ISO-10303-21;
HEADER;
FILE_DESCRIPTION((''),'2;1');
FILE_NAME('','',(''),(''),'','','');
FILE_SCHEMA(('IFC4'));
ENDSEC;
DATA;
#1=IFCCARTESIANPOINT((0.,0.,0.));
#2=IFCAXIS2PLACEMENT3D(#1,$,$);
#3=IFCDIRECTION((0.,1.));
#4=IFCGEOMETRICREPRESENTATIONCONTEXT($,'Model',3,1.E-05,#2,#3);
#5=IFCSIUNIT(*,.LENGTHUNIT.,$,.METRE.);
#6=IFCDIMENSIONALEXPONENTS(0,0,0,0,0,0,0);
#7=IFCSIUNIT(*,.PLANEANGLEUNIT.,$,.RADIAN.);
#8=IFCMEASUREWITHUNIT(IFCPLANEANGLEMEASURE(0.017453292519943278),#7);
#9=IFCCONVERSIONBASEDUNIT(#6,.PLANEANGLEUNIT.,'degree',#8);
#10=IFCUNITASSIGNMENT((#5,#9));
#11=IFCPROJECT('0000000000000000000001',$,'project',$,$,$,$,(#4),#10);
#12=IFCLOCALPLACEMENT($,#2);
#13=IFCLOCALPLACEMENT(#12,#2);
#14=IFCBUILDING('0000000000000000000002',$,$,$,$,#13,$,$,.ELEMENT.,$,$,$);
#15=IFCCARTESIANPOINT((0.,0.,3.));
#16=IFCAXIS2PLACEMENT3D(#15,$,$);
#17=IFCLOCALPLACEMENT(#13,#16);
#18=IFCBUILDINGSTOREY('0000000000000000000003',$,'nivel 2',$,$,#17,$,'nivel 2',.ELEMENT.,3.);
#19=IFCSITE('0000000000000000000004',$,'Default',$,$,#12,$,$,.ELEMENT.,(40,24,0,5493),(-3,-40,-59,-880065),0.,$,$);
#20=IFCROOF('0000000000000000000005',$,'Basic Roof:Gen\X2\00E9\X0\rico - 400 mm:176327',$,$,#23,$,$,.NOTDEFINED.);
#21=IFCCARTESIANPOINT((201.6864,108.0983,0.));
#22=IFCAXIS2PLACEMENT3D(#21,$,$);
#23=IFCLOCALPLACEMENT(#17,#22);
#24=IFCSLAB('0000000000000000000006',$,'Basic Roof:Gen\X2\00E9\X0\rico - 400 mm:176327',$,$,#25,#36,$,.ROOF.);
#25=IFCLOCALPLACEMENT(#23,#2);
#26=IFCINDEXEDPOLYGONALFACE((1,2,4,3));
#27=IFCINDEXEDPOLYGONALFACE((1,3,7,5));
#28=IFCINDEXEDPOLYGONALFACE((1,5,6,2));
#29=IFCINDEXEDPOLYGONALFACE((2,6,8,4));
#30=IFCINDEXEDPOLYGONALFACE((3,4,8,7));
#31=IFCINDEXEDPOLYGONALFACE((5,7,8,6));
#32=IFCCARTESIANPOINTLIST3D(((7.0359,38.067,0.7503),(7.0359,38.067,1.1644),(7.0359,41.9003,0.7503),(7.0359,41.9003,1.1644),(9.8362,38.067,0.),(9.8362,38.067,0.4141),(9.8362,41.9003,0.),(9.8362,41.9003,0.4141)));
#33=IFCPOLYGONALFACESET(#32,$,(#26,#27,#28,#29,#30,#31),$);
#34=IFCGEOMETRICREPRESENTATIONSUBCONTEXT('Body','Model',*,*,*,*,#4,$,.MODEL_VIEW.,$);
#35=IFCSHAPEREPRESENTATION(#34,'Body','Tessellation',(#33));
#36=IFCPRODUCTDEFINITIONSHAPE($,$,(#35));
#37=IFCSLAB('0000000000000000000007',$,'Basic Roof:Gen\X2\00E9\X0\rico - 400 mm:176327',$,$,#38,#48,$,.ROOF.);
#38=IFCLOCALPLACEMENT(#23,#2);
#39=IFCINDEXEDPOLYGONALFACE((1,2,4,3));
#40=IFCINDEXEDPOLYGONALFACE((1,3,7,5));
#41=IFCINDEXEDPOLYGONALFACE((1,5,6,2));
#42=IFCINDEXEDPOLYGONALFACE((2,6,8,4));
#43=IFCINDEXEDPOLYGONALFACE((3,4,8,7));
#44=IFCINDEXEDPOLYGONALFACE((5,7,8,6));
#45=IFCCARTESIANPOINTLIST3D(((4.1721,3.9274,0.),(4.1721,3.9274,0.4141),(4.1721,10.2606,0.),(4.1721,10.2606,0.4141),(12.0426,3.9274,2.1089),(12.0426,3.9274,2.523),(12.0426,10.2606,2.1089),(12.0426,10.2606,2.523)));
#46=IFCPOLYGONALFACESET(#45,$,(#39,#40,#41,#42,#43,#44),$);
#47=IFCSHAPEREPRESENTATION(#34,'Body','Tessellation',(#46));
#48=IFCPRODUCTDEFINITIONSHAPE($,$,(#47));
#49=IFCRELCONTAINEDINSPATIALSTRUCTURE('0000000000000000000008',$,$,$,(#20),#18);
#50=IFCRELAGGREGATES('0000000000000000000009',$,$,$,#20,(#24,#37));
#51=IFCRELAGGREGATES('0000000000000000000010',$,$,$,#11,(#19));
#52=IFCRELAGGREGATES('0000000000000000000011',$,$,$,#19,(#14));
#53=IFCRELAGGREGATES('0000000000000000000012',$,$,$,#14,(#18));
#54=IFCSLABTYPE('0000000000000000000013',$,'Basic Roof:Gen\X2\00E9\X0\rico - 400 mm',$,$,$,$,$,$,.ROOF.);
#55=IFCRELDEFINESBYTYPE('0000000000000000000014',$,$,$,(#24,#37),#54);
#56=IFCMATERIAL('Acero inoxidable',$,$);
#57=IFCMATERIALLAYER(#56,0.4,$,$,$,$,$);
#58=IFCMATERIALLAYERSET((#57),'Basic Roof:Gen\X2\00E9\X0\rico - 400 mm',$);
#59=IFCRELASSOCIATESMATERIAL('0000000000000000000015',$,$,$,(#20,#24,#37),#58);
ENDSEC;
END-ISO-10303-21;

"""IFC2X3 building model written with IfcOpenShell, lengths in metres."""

from ifc_helpers import new_model, entity, si_unit, converted_unit, direction, frame, frame_2d, origin, place, context, subcontext, project, spatial, rectangle, extrude, material, layer, layer_set, type_object, element, aggregate, save


model = new_model("IFC2X3")

# Units and contexts
model_context = context("Model", 3, precision=1e-05, world=origin(), true_north=direction((0.0, 1.0)))
body_context = subcontext(model_context, "Body", "Model", "MODEL_VIEW")
ifc_project = project(units=[si_unit("LENGTHUNIT", "METRE"), converted_unit("PLANEANGLEUNIT", "degree", entity("IfcPlaneAngleMeasure", 0.017453292519943278), si_unit("PLANEANGLEUNIT", "RADIAN"), dimensions=[0, 0, 0, 0, 0, 0, 0])], contexts=[model_context])

# Site, building, storey
site_placement = place(None, origin())
site = spatial("IfcSite", under=ifc_project, at=site_placement, Name="Default", CompositionType="ELEMENT", RefLatitude=(40, 24, 0, 5493), RefLongitude=(-3, -40, -59, -880065), RefElevation=0.0)
building_placement = place(site_placement, origin())
building = spatial("IfcBuilding", under=site, at=building_placement, CompositionType="ELEMENT")
storey_placement = place(building_placement, frame((0.0, 0.0, 3.0)))
storey = spatial("IfcBuildingStorey", under=building, at=storey_placement, Name="nivel 2", LongName="nivel 2", CompositionType="ELEMENT", Elevation=3.0)

# Shared definitions
ifc_material_1 = material(Name="Acero inoxidable")
ifc_layer_1 = layer(ifc_material_1, 0.4)
ifc_layer_set_1 = layer_set([ifc_layer_1], Name="Basic Roof:Genérico - 400 mm")
slab_type = type_object("IfcSlabType", Name="Basic Roof:Genérico - 400 mm", PredefinedType="ROOF")

# Roof, slabs
roof_1_placement = place(storey_placement, frame((201.6864, 108.0983, 0.0)))
roof_1 = element("IfcRoof", 1, at=roof_1_placement, inside=storey, material=ifc_layer_set_1, Name="Basic Roof:Genérico - 400 mm:176327", ShapeType="NOTDEFINED")
slab_1_placement = place(roof_1_placement, origin())
slab_1 = element("IfcSlab", 2, at=slab_1_placement, type_object=slab_type, material=ifc_layer_set_1, Name="Basic Roof:Genérico - 400 mm:176327", PredefinedType="ROOF", context=body_context, shape_type="SweptSolid", body=[
    extrude(rectangle(XDim=2.899, YDim=3.8333, at=frame_2d((0.0, 0.0), x_axis=(1.0, 0.0))), frame((8.4361, 39.9837, 0.3752), z_axis=(0.258819, 0.0, 0.965926), x_axis=(0.965926, 0.0, -0.258819)), (-0.258819, 0.0, 0.965926), 0.4141),
])
slab_2_placement = place(roof_1_placement, origin())
slab_2 = element("IfcSlab", 3, at=slab_2_placement, type_object=slab_type, material=ifc_layer_set_1, Name="Basic Roof:Genérico - 400 mm:176327", PredefinedType="ROOF", context=body_context, shape_type="SweptSolid", body=[
    extrude(rectangle(XDim=6.3332, YDim=8.1481, at=frame_2d((0.0, 0.0), x_axis=(0.0, 1.0))), frame((8.1074, 7.094, 1.0544), z_axis=(-0.258819, 0.0, 0.965926), x_axis=(0.965926, 0.0, 0.258819)), (0.258819, 0.0, 0.965926), 0.4141),
])
aggregate(roof_1, [slab_1, slab_2])

save(model, "model.ifc")
